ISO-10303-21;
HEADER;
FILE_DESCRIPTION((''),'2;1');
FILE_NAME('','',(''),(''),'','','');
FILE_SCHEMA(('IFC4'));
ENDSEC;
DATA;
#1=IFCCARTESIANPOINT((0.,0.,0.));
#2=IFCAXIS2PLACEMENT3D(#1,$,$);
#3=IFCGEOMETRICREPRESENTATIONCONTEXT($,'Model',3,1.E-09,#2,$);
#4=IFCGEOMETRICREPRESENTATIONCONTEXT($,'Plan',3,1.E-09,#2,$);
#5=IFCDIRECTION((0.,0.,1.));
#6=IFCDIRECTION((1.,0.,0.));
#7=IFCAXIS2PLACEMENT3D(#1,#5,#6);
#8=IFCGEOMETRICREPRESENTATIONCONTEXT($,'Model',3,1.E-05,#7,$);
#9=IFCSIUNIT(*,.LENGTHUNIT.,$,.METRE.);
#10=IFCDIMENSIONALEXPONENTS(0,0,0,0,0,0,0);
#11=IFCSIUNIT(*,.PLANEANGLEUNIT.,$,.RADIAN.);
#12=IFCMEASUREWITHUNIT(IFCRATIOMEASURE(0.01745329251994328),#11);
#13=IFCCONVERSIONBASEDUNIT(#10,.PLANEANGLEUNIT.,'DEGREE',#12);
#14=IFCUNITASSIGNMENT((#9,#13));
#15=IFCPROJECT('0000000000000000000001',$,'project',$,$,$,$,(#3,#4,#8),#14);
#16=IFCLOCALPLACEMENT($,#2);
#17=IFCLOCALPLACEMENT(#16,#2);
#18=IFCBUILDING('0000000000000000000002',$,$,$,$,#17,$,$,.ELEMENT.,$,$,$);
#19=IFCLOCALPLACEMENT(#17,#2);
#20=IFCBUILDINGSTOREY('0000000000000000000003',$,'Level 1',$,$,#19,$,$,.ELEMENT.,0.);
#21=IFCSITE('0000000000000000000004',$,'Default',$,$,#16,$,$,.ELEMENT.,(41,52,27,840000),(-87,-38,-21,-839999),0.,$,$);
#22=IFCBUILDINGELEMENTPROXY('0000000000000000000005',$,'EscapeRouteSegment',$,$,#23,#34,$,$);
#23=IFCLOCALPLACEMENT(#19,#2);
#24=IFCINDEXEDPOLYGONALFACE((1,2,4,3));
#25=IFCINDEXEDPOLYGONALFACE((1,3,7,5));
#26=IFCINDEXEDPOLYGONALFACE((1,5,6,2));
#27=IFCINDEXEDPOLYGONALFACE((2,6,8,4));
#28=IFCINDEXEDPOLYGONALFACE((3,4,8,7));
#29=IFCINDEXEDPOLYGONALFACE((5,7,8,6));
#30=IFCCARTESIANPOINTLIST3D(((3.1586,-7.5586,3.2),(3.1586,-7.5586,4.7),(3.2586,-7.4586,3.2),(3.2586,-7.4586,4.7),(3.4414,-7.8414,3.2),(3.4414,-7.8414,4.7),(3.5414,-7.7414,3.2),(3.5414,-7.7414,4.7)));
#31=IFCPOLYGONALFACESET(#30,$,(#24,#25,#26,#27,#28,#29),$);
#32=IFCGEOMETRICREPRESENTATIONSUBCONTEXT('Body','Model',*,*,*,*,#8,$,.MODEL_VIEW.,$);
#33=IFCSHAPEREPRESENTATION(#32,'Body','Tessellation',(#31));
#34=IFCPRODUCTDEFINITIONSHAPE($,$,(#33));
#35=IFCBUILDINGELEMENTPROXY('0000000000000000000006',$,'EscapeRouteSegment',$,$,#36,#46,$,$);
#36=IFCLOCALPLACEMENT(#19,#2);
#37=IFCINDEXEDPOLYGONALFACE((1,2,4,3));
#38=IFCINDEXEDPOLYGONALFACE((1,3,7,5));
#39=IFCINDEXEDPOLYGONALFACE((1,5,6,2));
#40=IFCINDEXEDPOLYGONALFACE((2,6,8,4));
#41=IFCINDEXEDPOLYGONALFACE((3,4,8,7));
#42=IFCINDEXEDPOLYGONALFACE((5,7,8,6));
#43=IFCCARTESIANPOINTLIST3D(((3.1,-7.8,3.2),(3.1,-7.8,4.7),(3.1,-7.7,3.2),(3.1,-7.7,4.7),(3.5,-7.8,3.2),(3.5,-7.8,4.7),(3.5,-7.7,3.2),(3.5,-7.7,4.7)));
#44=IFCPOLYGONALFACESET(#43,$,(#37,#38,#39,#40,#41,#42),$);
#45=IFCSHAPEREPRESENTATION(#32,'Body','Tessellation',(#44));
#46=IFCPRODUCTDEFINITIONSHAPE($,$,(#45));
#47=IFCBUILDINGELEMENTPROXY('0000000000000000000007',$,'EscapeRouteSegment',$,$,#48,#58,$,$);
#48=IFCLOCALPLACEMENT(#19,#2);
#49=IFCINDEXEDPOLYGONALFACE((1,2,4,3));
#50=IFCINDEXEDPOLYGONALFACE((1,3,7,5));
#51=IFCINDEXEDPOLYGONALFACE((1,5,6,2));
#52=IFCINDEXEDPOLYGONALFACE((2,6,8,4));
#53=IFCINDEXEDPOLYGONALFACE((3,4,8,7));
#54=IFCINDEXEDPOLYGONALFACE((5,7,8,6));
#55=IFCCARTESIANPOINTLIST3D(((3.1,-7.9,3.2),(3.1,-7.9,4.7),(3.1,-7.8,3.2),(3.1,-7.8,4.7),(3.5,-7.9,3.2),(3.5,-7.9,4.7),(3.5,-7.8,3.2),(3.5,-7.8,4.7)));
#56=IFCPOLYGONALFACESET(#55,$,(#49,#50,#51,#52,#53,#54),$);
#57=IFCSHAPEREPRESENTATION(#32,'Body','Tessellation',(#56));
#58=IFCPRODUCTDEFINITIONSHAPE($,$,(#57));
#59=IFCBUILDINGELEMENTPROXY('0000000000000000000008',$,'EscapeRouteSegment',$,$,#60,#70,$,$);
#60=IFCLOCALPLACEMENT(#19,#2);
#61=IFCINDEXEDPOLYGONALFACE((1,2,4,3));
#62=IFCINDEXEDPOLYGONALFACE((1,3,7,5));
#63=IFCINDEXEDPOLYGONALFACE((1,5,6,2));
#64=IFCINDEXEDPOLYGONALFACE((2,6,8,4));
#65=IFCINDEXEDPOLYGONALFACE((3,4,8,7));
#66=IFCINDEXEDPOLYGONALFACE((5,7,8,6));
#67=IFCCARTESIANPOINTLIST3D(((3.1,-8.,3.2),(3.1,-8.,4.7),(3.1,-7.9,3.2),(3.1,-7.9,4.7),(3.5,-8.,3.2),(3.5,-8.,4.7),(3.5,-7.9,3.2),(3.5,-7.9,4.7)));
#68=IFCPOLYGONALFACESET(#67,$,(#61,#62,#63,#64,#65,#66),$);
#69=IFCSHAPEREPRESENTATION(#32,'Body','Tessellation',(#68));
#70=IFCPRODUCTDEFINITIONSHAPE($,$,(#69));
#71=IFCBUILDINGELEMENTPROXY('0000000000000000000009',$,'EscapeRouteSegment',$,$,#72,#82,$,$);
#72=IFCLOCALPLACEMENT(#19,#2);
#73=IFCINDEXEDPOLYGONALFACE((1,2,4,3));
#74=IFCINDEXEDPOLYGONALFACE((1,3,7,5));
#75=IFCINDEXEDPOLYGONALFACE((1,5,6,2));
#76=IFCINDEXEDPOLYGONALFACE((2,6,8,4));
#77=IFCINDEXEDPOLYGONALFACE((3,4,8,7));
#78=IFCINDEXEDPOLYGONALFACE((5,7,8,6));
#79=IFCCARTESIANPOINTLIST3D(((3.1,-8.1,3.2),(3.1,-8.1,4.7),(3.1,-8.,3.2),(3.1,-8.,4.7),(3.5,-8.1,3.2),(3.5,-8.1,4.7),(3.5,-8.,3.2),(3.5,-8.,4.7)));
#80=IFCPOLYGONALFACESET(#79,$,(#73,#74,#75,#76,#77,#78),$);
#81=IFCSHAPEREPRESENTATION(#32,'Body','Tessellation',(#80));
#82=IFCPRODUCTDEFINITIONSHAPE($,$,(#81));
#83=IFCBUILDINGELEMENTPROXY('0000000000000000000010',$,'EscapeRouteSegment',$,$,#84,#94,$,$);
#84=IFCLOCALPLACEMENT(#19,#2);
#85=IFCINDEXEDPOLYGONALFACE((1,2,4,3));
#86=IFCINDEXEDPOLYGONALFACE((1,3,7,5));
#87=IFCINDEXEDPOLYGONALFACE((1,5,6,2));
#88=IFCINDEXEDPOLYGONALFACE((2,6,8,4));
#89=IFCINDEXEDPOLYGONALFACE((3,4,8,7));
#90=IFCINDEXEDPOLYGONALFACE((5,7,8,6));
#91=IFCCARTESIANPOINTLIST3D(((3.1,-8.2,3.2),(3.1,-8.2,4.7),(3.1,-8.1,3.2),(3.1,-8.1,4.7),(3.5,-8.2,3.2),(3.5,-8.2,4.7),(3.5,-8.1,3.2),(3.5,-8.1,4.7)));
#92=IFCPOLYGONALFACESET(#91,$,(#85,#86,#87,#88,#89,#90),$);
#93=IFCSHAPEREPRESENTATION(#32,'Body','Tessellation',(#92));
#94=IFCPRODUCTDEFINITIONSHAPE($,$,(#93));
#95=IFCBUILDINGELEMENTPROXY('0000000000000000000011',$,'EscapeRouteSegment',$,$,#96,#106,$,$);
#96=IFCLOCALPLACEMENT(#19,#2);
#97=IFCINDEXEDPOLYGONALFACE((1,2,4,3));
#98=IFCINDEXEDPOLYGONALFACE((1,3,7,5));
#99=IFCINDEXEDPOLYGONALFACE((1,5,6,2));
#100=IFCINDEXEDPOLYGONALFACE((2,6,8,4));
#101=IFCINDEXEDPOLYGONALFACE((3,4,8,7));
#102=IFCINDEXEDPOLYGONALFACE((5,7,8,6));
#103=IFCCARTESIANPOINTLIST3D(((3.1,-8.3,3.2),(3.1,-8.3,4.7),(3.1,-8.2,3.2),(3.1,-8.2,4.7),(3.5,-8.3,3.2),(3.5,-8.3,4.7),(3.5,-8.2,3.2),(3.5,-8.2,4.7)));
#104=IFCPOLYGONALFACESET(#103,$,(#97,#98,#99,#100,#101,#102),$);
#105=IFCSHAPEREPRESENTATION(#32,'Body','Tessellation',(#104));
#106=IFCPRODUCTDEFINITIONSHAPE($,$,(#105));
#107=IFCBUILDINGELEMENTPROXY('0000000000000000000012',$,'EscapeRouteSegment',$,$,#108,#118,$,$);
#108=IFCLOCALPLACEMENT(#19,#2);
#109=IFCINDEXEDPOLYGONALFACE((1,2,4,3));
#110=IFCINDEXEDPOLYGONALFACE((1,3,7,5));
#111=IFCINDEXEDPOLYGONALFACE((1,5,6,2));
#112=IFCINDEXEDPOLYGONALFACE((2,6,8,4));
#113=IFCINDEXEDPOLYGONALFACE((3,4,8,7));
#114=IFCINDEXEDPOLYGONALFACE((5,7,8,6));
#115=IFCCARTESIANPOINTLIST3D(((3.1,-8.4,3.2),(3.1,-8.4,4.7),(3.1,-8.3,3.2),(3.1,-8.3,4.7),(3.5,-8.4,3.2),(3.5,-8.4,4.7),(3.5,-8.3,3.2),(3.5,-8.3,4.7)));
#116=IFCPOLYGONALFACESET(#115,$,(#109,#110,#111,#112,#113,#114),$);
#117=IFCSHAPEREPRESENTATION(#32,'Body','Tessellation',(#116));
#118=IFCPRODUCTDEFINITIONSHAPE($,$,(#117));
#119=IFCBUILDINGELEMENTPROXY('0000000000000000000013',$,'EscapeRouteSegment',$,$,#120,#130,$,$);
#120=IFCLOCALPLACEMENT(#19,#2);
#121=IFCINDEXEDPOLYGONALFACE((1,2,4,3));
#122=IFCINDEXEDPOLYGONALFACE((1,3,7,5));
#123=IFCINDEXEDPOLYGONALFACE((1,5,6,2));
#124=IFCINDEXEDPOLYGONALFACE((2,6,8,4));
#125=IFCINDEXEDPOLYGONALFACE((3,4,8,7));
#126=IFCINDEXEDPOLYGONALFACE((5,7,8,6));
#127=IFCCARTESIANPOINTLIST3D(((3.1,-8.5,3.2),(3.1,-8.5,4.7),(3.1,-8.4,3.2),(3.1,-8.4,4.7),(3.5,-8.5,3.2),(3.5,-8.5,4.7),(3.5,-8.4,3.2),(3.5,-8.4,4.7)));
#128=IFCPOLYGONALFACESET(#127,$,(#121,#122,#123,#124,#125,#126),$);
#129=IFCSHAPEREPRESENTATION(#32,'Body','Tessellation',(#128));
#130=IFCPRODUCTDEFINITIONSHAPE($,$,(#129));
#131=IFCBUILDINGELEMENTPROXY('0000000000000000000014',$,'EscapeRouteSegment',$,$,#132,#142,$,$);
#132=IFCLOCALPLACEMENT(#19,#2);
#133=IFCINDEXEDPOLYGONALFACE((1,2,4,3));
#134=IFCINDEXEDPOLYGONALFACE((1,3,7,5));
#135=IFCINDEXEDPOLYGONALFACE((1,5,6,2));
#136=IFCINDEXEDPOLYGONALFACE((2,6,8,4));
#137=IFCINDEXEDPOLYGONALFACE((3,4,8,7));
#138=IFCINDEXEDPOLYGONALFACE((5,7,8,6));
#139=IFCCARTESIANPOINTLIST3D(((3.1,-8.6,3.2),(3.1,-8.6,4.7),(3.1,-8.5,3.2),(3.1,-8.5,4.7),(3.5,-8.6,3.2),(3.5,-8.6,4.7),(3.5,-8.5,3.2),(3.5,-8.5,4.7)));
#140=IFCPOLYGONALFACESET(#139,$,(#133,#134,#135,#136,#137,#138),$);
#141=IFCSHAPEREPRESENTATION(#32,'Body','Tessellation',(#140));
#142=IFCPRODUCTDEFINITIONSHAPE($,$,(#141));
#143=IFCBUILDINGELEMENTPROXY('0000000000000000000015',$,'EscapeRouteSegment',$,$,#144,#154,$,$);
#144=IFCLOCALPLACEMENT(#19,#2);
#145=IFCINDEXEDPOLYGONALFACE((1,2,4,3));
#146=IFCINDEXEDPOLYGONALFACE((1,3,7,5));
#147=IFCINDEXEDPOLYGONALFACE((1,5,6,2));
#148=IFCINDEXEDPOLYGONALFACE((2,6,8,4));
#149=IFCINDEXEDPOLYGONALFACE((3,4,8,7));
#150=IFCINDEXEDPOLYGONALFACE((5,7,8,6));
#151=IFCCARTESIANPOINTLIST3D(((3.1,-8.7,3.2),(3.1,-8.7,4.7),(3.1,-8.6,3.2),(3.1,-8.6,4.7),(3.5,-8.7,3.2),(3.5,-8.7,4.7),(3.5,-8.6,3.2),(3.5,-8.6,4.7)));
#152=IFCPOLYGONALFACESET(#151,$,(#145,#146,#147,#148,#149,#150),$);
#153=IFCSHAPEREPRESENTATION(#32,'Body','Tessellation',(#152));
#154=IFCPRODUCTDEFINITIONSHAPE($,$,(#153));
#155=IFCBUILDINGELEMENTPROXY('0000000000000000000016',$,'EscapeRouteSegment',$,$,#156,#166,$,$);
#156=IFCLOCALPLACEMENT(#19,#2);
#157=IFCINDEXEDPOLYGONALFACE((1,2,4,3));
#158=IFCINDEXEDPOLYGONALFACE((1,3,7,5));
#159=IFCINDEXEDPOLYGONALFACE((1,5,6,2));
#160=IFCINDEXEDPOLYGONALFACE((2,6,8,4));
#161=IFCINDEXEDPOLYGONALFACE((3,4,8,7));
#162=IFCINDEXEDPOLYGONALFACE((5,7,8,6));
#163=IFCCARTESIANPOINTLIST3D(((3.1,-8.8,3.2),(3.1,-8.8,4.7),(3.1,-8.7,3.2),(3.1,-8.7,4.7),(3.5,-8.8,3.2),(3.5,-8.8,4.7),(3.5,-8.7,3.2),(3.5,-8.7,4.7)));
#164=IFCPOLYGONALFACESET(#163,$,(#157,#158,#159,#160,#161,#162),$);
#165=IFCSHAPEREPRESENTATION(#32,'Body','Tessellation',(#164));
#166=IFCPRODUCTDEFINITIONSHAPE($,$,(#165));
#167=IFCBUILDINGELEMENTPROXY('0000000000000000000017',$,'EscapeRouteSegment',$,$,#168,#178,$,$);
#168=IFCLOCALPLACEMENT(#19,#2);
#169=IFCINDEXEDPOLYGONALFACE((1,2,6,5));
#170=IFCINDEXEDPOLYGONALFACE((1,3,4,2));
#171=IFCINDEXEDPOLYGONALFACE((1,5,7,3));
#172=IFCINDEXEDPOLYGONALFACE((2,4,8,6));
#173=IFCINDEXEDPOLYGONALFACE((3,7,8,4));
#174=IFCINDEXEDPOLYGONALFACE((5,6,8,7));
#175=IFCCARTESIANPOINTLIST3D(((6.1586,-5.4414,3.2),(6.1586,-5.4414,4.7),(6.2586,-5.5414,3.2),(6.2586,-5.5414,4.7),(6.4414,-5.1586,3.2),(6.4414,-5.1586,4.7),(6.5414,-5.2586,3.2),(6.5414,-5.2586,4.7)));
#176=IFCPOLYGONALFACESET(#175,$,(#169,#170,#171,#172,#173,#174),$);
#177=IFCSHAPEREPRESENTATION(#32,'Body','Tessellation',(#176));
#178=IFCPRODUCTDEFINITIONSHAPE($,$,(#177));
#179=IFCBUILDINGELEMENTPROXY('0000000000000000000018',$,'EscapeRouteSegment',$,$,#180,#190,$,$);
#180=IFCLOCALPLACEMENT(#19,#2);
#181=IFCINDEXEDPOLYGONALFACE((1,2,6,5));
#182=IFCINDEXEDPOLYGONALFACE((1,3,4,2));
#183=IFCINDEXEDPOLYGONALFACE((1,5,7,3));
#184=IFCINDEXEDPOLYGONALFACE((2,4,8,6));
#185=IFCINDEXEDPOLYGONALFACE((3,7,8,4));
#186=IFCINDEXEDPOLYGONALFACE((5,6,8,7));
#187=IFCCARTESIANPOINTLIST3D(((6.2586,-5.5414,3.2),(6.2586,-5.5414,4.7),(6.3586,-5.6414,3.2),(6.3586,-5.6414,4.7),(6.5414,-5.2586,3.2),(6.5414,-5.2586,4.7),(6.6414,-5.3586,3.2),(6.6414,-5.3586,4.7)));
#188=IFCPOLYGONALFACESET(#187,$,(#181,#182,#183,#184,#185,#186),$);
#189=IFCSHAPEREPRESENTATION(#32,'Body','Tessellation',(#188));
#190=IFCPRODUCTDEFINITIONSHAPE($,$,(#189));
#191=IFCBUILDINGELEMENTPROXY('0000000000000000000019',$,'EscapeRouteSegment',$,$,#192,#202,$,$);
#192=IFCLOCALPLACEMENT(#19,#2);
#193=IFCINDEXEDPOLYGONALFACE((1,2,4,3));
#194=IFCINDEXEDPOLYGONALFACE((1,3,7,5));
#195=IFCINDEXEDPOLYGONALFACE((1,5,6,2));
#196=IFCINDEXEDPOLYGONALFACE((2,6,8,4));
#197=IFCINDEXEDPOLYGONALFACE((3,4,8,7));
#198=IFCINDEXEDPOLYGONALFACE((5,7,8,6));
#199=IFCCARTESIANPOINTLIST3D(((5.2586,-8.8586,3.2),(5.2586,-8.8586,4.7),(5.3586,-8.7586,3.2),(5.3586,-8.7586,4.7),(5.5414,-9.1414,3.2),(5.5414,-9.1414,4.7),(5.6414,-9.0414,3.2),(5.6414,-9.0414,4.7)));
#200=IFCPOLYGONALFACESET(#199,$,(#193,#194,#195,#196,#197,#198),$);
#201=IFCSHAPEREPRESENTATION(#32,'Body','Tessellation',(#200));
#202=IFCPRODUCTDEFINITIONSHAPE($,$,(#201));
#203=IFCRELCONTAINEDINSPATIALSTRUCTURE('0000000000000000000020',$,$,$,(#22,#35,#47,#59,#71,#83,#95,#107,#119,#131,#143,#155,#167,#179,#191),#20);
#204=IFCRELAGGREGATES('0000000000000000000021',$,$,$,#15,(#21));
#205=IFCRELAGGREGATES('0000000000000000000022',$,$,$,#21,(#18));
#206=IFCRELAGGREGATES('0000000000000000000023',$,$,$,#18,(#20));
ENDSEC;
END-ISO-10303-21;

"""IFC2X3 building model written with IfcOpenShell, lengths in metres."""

from ifc_helpers import new_model, entity, si_unit, converted_unit, frame, origin, origin_with_axes, place, context, subcontext, project, spatial, polyline, outline, extrude, element, save


model = new_model("IFC2X3")

# Units and contexts
model_context_1 = context("Model", 3, precision=1e-09, world=origin())
plan_context = context("Plan", 3, precision=1e-09, world=origin())
model_context_2 = context("Model", 3, precision=1e-05, world=origin_with_axes())
body_context = subcontext(model_context_2, "Body", "Model", "MODEL_VIEW")
ifc_project = project(units=[si_unit("LENGTHUNIT", "METRE"), converted_unit("PLANEANGLEUNIT", "DEGREE", entity("IfcRatioMeasure", 0.01745329251994328), si_unit("PLANEANGLEUNIT", "RADIAN"), dimensions=[0, 0, 0, 0, 0, 0, 0])], contexts=[model_context_1, plan_context, model_context_2])

# Site, building, storey
site_placement = place(None, origin())
site = spatial("IfcSite", under=ifc_project, at=site_placement, Name="Default", CompositionType="ELEMENT", RefLatitude=(41, 52, 27, 840000), RefLongitude=(-87, -38, -21, -839999), RefElevation=0.0)
building_placement = place(site_placement, origin())
building = spatial("IfcBuilding", under=site, at=building_placement, CompositionType="ELEMENT")
storey_placement = place(building_placement, origin())
storey = spatial("IfcBuildingStorey", under=building, at=storey_placement, Name="Level 1", CompositionType="ELEMENT", Elevation=0.0)

# Building element proxies
proxy_1_placement = place(storey_placement, frame((3.4, -7.6, 3.2), z_axis=(0.0, 0.0, 1.0), x_axis=(-0.707108, -0.707106, 0.0)))
element("IfcBuildingElementProxy", 1, at=proxy_1_placement, inside=storey, Name="EscapeRouteSegment", context=body_context, shape_type="SweptSolid", body=[
    extrude(outline(polyline([(0.0, -0.2), (0.0, 0.2), (0.1414, 0.2), (0.1414, -0.2), (0.0, -0.2)])), origin_with_axes(), (0.0, 0.0, 1.0), 1.5),
])
proxy_2_placement = place(storey_placement, frame((3.3, -7.7, 3.2), z_axis=(0.0, 0.0, 1.0), x_axis=(0.0, -1.0, 0.0)))
element("IfcBuildingElementProxy", 2, at=proxy_2_placement, inside=storey, Name="EscapeRouteSegment", context=body_context, shape_type="SweptSolid", body=[
    extrude(outline(polyline([(0.0, -0.2), (0.0, 0.2), (0.1, 0.2), (0.1, -0.2), (0.0, -0.2)])), origin_with_axes(), (0.0, 0.0, 1.0), 1.5),
])
for number, where, z_axis, x_axis, name in (
    (3, (3.3, -7.8, 3.2), (0.0, 0.0, 1.0), (0.0, -1.0, 0.0), "EscapeRouteSegment"),
    (4, (3.3, -7.9, 3.2), (0.0, 0.0, 1.0), (0.0, -1.0, 0.0), "EscapeRouteSegment"),
):
    element("IfcBuildingElementProxy", number, at=place(storey_placement, frame(where, z_axis=z_axis, x_axis=x_axis)), inside=storey, Name=name, context=body_context, shape_type="SweptSolid", body=[
        extrude(outline(polyline([(0.0, -0.2), (0.0, 0.2), (0.1, 0.2), (0.1, -0.2), (0.0, -0.2)])), origin_with_axes(), (0.0, 0.0, 1.0), 1.5),
    ])
proxy_3_placement = place(storey_placement, frame((3.3, -8.0, 3.2), z_axis=(0.0, 0.0, 1.0), x_axis=(0.0, -1.0, 0.0)))
element("IfcBuildingElementProxy", 5, at=proxy_3_placement, inside=storey, Name="EscapeRouteSegment", context=body_context, shape_type="SweptSolid", body=[
    extrude(outline(polyline([(0.0, -0.2), (0.0, 0.2), (0.1, 0.2), (0.1, -0.2), (0.0, -0.2)])), origin_with_axes(), (0.0, 0.0, 1.0), 1.5),
])
proxy_4_placement = place(storey_placement, frame((3.3, -8.1, 3.2), z_axis=(0.0, 0.0, 1.0), x_axis=(0.0, -1.0, 0.0)))
element("IfcBuildingElementProxy", 6, at=proxy_4_placement, inside=storey, Name="EscapeRouteSegment", context=body_context, shape_type="SweptSolid", body=[
    extrude(outline(polyline([(0.0, -0.2), (0.0, 0.2), (0.1, 0.2), (0.1, -0.2), (0.0, -0.2)])), origin_with_axes(), (0.0, 0.0, 1.0), 1.5),
])
proxy_5_placement = place(storey_placement, frame((3.3, -8.2, 3.2), z_axis=(0.0, 0.0, 1.0), x_axis=(0.0, -1.0, 0.0)))
element("IfcBuildingElementProxy", 7, at=proxy_5_placement, inside=storey, Name="EscapeRouteSegment", context=body_context, shape_type="SweptSolid", body=[
    extrude(outline(polyline([(0.0, -0.2), (0.0, 0.2), (0.1, 0.2), (0.1, -0.2), (0.0, -0.2)])), origin_with_axes(), (0.0, 0.0, 1.0), 1.5),
])
proxy_6_placement = place(storey_placement, frame((3.3, -8.3, 3.2), z_axis=(0.0, 0.0, 1.0), x_axis=(0.0, -1.0, 0.0)))
element("IfcBuildingElementProxy", 8, at=proxy_6_placement, inside=storey, Name="EscapeRouteSegment", context=body_context, shape_type="SweptSolid", body=[
    extrude(outline(polyline([(0.0, -0.2), (0.0, 0.2), (0.1, 0.2), (0.1, -0.2), (0.0, -0.2)])), origin_with_axes(), (0.0, 0.0, 1.0), 1.5),
])
for number, where, z_axis, x_axis, name in (
    (9, (3.3, -8.4, 3.2), (0.0, 0.0, 1.0), (0.0, -1.0, 0.0), "EscapeRouteSegment"),
    (10, (3.3, -8.5, 3.2), (0.0, 0.0, 1.0), (0.0, -1.0, 0.0), "EscapeRouteSegment"),
):
    element("IfcBuildingElementProxy", number, at=place(storey_placement, frame(where, z_axis=z_axis, x_axis=x_axis)), inside=storey, Name=name, context=body_context, shape_type="SweptSolid", body=[
        extrude(outline(polyline([(0.0, -0.2), (0.0, 0.2), (0.1, 0.2), (0.1, -0.2), (0.0, -0.2)])), origin_with_axes(), (0.0, 0.0, 1.0), 1.5),
    ])
proxy_7_placement = place(storey_placement, frame((3.3, -8.6, 3.2), z_axis=(0.0, 0.0, 1.0), x_axis=(0.0, -1.0, 0.0)))
element("IfcBuildingElementProxy", 11, at=proxy_7_placement, inside=storey, Name="EscapeRouteSegment", context=body_context, shape_type="SweptSolid", body=[
    extrude(outline(polyline([(0.0, -0.2), (0.0, 0.2), (0.1, 0.2), (0.1, -0.2), (0.0, -0.2)])), origin_with_axes(), (0.0, 0.0, 1.0), 1.5),
])
proxy_8_placement = place(storey_placement, frame((3.3, -8.7, 3.2), z_axis=(0.0, 0.0, 1.0), x_axis=(0.0, -1.0, 0.0)))
element("IfcBuildingElementProxy", 12, at=proxy_8_placement, inside=storey, Name="EscapeRouteSegment", context=body_context, shape_type="SweptSolid", body=[
    extrude(outline(polyline([(0.0, -0.2), (0.0, 0.2), (0.1, 0.2), (0.1, -0.2), (0.0, -0.2)])), origin_with_axes(), (0.0, 0.0, 1.0), 1.5),
])
for number, where, z_axis, x_axis, name in (
    (13, (6.3, -5.3, 3.2), (0.0, 0.0, 1.0), (0.707107, -0.707107, 0.0), "EscapeRouteSegment"),
    (14, (6.4, -5.4, 3.2), (0.0, 0.0, 1.0), (0.707107, -0.707107, 0.0), "EscapeRouteSegment"),
):
    element("IfcBuildingElementProxy", number, at=place(storey_placement, frame(where, z_axis=z_axis, x_axis=x_axis)), inside=storey, Name=name, context=body_context, shape_type="SweptSolid", body=[
        extrude(outline(polyline([(0.0, -0.2), (0.0, 0.2), (0.1414, 0.2), (0.1414, -0.2), (0.0, -0.2)])), origin_with_axes(), (0.0, 0.0, 1.0), 1.5),
    ])
proxy_9_placement = place(storey_placement, frame((5.4, -9.0, 3.2), z_axis=(0.0, 0.0, 1.0), x_axis=(0.707105, 0.707108, 0.0)))
element("IfcBuildingElementProxy", 15, at=proxy_9_placement, inside=storey, Name="EscapeRouteSegment", context=body_context, shape_type="SweptSolid", body=[
    extrude(outline(polyline([(0.0, -0.2), (0.0, 0.2), (0.1414, 0.2), (0.1414, -0.2), (0.0, -0.2)])), origin_with_axes(), (0.0, 0.0, 1.0), 1.5),
])

save(model, "model.ifc")
